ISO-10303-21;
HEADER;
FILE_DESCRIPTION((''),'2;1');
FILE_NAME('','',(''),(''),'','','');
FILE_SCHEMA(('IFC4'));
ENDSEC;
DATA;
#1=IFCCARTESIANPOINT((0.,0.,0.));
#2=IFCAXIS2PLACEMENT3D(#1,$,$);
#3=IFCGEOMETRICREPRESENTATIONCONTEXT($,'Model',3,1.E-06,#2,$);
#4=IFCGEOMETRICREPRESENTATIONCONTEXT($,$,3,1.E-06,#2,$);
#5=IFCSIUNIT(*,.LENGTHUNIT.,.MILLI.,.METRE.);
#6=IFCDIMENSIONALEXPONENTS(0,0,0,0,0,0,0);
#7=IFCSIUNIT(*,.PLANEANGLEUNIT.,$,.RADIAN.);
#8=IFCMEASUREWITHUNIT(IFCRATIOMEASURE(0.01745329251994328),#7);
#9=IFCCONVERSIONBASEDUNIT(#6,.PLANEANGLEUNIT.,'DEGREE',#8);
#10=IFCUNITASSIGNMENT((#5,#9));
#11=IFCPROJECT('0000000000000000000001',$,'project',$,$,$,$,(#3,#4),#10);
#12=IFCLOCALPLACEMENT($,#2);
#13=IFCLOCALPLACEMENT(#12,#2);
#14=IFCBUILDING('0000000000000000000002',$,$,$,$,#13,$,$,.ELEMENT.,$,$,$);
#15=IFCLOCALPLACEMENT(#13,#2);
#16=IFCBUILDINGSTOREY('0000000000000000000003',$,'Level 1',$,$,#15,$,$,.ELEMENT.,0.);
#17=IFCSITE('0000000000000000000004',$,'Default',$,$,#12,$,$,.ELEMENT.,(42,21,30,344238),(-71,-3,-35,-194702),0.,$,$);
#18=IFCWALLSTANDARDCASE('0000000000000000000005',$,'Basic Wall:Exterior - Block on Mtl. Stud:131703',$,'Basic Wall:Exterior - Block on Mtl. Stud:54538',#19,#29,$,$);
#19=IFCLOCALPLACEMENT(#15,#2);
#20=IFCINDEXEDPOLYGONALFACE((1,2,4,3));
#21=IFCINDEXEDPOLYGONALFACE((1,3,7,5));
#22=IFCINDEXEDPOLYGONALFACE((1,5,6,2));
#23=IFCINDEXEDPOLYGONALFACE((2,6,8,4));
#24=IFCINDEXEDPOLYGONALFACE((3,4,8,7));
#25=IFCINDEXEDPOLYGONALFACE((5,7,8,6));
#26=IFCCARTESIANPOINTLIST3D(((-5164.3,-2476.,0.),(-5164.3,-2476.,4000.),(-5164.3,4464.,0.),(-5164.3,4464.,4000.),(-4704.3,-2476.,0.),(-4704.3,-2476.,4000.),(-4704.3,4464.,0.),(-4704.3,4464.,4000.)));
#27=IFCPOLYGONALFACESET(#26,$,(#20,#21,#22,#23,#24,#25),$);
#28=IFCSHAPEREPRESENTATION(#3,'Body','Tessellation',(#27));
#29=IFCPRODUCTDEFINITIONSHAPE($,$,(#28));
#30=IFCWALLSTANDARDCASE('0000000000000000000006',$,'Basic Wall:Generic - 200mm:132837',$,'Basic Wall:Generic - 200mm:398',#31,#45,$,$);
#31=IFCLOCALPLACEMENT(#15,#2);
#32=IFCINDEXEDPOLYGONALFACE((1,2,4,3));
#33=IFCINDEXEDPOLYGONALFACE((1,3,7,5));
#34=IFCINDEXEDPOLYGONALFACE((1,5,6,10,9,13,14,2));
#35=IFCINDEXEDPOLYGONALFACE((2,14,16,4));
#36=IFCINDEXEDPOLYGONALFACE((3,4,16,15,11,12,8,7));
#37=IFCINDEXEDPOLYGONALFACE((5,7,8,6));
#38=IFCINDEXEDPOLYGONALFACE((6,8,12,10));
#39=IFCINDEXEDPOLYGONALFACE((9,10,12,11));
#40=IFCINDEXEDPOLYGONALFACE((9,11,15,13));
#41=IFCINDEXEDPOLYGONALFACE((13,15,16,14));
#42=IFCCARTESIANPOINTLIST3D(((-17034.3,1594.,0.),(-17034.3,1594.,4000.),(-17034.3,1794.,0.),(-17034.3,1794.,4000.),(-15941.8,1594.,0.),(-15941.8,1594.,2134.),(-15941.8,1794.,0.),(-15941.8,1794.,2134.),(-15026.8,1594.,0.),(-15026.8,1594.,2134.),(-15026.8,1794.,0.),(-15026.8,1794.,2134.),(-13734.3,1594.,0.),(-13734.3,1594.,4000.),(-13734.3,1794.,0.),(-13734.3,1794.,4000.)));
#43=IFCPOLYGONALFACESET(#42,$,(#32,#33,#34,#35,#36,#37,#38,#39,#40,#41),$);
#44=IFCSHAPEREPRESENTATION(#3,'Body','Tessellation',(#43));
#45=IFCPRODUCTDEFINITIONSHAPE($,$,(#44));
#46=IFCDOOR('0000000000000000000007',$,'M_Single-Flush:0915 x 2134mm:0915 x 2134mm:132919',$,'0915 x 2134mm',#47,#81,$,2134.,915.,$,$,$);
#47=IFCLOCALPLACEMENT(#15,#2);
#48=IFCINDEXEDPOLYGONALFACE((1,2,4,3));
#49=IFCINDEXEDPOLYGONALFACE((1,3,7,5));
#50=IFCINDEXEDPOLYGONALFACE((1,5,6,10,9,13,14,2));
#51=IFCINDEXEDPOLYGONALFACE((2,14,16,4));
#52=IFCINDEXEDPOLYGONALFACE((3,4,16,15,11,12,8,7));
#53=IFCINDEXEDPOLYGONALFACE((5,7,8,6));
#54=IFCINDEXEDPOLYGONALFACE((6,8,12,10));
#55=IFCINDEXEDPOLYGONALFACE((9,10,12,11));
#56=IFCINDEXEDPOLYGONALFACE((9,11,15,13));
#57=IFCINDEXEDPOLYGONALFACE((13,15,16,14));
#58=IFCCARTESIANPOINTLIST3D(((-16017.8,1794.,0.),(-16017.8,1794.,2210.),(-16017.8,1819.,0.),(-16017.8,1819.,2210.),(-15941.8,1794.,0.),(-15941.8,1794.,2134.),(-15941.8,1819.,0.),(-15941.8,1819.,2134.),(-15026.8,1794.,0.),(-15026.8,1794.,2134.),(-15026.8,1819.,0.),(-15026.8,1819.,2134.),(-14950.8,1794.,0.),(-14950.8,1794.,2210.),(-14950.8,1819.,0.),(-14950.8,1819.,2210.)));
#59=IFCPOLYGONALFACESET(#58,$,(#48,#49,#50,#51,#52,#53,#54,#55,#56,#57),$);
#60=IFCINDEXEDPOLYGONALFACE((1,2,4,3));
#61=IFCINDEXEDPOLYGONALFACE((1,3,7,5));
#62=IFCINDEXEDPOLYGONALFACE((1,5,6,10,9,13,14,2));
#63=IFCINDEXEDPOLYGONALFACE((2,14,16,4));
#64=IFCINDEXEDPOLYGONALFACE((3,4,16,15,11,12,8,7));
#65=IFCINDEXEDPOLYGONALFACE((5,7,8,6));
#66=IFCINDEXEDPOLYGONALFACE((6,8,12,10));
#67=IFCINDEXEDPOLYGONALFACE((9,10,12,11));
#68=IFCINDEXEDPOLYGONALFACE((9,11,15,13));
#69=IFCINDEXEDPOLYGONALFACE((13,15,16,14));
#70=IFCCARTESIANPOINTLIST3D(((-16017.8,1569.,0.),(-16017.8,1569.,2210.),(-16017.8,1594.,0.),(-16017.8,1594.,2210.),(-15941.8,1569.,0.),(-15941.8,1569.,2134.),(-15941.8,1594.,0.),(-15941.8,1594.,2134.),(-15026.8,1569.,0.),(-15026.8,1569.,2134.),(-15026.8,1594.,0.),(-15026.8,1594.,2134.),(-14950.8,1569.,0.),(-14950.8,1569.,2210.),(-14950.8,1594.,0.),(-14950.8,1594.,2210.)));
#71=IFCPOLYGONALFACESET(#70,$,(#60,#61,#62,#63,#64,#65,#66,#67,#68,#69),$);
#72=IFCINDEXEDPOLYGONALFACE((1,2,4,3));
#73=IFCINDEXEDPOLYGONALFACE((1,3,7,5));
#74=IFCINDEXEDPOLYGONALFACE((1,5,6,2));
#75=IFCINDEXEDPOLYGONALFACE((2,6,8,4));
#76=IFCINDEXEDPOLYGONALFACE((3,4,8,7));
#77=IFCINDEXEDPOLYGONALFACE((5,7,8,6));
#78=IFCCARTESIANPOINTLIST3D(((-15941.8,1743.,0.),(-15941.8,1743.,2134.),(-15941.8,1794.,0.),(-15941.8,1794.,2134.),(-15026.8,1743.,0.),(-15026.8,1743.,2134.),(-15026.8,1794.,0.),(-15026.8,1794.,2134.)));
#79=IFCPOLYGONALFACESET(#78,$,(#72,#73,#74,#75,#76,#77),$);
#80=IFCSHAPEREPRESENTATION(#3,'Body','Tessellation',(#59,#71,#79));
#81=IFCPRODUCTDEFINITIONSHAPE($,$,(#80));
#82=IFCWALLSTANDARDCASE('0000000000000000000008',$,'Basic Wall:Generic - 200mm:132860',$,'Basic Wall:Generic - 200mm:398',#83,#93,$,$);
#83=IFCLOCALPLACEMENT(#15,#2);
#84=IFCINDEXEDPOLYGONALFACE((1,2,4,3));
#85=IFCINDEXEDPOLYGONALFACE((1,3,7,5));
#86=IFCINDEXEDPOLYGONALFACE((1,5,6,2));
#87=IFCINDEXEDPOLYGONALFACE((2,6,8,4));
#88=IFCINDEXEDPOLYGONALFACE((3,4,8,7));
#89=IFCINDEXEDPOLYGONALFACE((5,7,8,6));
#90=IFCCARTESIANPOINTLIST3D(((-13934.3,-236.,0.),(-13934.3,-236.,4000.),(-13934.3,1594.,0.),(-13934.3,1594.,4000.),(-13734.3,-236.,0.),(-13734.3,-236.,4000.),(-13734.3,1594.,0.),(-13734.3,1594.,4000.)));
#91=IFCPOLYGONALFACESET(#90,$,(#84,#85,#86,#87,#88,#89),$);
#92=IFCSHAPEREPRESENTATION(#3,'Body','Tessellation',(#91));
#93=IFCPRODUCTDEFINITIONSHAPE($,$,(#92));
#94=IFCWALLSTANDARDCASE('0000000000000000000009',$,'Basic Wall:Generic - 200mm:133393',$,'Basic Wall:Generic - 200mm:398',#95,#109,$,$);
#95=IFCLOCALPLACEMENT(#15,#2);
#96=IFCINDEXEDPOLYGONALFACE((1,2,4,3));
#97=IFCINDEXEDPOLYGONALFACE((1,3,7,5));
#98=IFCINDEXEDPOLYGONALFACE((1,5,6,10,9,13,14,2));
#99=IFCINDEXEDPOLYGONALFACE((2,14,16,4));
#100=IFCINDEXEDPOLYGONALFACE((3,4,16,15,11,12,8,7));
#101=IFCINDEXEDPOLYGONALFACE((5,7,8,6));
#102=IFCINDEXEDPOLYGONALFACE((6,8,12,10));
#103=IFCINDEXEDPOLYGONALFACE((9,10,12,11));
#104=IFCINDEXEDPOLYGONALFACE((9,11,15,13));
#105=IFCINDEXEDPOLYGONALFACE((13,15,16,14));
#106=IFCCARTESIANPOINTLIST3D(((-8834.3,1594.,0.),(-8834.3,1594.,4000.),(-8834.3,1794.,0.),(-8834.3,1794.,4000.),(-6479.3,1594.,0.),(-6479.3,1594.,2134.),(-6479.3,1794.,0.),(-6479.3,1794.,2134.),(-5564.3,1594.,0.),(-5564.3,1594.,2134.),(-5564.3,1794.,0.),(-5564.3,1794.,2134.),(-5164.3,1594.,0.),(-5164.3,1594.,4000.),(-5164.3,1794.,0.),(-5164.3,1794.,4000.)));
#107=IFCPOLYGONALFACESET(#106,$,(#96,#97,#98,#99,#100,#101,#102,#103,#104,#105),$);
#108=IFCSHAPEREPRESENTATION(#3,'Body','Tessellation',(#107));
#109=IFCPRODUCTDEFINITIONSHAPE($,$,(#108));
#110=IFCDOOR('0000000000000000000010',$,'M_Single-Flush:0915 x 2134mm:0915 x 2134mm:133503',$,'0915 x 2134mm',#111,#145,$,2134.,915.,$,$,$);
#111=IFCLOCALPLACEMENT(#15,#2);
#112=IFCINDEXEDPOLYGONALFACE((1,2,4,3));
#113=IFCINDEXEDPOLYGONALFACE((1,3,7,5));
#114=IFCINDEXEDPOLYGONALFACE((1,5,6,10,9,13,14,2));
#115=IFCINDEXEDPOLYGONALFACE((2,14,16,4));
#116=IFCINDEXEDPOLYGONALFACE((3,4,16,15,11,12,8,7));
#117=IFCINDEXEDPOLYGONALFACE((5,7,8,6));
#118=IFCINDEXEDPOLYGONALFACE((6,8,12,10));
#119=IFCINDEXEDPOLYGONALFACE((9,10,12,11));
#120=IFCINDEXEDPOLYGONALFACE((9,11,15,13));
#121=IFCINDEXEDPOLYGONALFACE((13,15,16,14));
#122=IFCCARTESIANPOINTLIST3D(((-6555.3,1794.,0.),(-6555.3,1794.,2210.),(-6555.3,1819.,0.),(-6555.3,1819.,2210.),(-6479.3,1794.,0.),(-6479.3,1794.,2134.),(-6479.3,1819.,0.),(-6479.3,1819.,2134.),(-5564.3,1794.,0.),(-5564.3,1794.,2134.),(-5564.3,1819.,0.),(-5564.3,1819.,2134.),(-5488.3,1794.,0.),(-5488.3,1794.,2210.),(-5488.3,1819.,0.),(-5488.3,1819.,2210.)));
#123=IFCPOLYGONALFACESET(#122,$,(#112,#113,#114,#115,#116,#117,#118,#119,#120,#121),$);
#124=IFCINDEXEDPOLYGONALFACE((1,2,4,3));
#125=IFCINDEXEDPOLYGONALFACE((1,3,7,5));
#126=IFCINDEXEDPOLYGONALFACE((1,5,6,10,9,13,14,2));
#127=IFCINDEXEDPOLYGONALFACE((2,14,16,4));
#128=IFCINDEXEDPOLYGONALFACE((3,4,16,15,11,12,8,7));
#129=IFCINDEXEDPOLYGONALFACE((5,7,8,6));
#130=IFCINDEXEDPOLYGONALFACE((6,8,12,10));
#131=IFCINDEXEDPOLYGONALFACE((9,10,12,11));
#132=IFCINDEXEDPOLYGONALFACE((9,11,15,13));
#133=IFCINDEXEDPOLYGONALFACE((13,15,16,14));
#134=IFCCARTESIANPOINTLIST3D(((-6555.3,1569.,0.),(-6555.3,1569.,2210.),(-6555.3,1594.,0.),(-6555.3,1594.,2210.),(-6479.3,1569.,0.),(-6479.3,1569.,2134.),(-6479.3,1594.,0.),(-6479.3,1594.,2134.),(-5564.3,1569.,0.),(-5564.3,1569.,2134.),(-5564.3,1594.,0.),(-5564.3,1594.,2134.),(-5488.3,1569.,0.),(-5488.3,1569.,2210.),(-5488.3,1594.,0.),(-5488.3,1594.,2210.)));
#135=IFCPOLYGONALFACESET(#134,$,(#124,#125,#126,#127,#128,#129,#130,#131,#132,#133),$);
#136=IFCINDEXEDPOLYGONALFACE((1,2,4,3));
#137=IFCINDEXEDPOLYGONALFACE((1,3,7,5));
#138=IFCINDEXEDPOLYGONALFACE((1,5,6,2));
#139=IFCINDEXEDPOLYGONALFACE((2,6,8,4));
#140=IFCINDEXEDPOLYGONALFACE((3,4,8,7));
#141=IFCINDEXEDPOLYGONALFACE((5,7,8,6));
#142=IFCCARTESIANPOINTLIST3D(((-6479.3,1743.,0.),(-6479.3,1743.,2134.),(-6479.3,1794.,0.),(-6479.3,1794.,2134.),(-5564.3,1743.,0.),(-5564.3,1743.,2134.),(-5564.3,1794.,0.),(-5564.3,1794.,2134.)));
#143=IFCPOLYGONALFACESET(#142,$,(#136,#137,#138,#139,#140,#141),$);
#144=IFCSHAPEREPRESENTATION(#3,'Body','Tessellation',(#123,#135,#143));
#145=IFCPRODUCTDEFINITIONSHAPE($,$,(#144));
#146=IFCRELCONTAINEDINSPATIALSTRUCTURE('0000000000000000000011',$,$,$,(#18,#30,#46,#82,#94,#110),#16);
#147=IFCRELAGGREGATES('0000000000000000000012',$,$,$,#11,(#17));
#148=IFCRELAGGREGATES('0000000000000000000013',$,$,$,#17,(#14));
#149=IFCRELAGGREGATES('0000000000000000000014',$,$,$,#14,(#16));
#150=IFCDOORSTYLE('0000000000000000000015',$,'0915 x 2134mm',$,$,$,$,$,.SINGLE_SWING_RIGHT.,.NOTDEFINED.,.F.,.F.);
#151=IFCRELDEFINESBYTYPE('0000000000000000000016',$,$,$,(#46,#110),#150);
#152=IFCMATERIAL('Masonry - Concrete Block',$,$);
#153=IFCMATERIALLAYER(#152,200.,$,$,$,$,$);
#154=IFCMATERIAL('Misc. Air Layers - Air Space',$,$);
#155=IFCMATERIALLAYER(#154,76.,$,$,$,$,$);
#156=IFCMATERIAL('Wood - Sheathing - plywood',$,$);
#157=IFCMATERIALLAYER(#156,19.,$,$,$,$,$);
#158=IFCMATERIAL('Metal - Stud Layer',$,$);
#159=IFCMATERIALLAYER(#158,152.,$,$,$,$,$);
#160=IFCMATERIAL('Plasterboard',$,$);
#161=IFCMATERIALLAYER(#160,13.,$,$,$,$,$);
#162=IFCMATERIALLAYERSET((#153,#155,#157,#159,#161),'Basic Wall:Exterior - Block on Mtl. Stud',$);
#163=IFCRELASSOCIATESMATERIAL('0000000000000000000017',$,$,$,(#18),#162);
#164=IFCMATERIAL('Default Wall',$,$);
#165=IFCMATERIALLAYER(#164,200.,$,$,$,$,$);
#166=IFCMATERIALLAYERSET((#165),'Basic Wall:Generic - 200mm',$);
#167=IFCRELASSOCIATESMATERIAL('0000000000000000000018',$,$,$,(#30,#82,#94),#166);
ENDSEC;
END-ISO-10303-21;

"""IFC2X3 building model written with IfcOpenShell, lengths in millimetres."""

from ifc_helpers import new_model, entity, si_unit, converted_unit, frame, frame_2d, origin, origin_2d_with_axis, place, context, project, spatial, polyline, rectangle, outline, extrude, source, transform, mapped, material, layer, layer_set, layer_usage, type_object, type_shapes, element, fill, save


model = new_model("IFC2X3")

# Units and contexts
model_context = context("Model", 3, precision=1e-06, world=origin())
context_of_model = context(None, 3, precision=1e-06, world=origin())
ifc_project = project(units=[si_unit("LENGTHUNIT", "METRE", prefix="MILLI"), converted_unit("PLANEANGLEUNIT", "DEGREE", entity("IfcRatioMeasure", 0.01745329251994328), si_unit("PLANEANGLEUNIT", "RADIAN"), dimensions=[0, 0, 0, 0, 0, 0, 0])], contexts=[model_context, context_of_model])

# Site, building, storey
site_placement = place(None, origin())
site = spatial("IfcSite", under=ifc_project, at=site_placement, Name="Default", CompositionType="ELEMENT", RefLatitude=(42, 21, 30, 344238), RefLongitude=(-71, -3, -35, -194702), RefElevation=0.0)
building_placement = place(site_placement, origin())
building = spatial("IfcBuilding", under=site, at=building_placement, CompositionType="ELEMENT")
storey_placement = place(building_placement, origin())
storey = spatial("IfcBuildingStorey", under=building, at=storey_placement, Name="Level 1", CompositionType="ELEMENT", Elevation=0.0)

# Shared definitions
ifc_material_1 = material(Name="Masonry - Concrete Block")
ifc_layer_1 = layer(ifc_material_1, 200.0)
ifc_material_2 = material(Name="Misc. Air Layers - Air Space")
ifc_layer_2 = layer(ifc_material_2, 76.0)
ifc_material_3 = material(Name="Wood - Sheathing - plywood")
ifc_layer_3 = layer(ifc_material_3, 19.0)
ifc_material_4 = material(Name="Metal - Stud Layer")
ifc_layer_4 = layer(ifc_material_4, 152.0)
ifc_material_5 = material(Name="Plasterboard")
ifc_layer_5 = layer(ifc_material_5, 13.0)
ifc_layer_set_1 = layer_set([ifc_layer_1, ifc_layer_2, ifc_layer_3, ifc_layer_4, ifc_layer_5], Name="Basic Wall:Exterior - Block on Mtl. Stud")

# Shared definitions
ifc_material_6 = material(Name="Default Wall")
ifc_layer_6 = layer(ifc_material_6, 200.0)
ifc_layer_set_2 = layer_set([ifc_layer_6], Name="Basic Wall:Generic - 200mm")
door_style = type_object("IfcDoorStyle", Name="0915 x 2134mm", ConstructionType="NOTDEFINED", OperationType="SINGLE_SWING_RIGHT", ParameterTakesPrecedence=False, Sizeable=False)
shared_shape_1 = source(origin(), model_context, "Body", "SweptSolid", [
    extrude(outline(polyline([(-533.5, -1124.0), (533.5, -1124.0), (533.5, 1086.0), (457.5, 1086.0), (457.5, -1048.0), (-457.5, -1048.0), (-457.5, 1086.0), (-533.5, 1086.0), (-533.5, -1124.0)])), frame((457.5, 200.0, 1086.0), z_axis=(0.0, 1.0, 0.0), x_axis=(1.0, 0.0, 0.0)), (0.0, 0.0, 1.0), 25.0),
    extrude(outline(polyline([(-1124.0, -533.5), (1086.0, -533.5), (1086.0, -457.5), (-1048.0, -457.5), (-1048.0, 457.5), (1086.0, 457.5), (1086.0, 533.5), (-1124.0, 533.5), (-1124.0, -533.5)])), frame((457.5, -25.0, 1086.0), z_axis=(0.0, 1.0, 0.0), x_axis=(0.0, 0.0, -1.0)), (0.0, 0.0, 1.0), 25.0),
    extrude(rectangle(XDim=51.0, YDim=915.0, at=origin_2d_with_axis()), frame((457.5, 174.5, 0.0), z_axis=(0.0, 0.0, 1.0), x_axis=(0.0, 1.0, 0.0)), (0.0, 0.0, 1.0), 2134.0),
])
type_shapes(door_style, [shared_shape_1])

# Wall
ifc_layer_usage_1 = layer_usage(ifc_layer_set_1, "AXIS2", "NEGATIVE", 230.0)
wall_1_placement = place(storey_placement, frame((-4934.3, 4464.0, 0.0), z_axis=(0.0, 0.0, 1.0), x_axis=(0.0, -1.0, 0.0)))
element("IfcWallStandardCase", 1, at=wall_1_placement, inside=storey, material=ifc_layer_usage_1, Name="Basic Wall:Exterior - Block on Mtl. Stud:131703", ObjectType="Basic Wall:Exterior - Block on Mtl. Stud:54538", context=model_context, shape_type="SweptSolid", body=[
    extrude(rectangle(XDim=6940.0, YDim=460.0, at=frame_2d((3470.0, 0.0), x_axis=(-1.0, 0.0))), origin(), (0.0, 0.0, 1.0), 4000.0),
])

# Wall, opening, door
ifc_layer_usage_2 = layer_usage(ifc_layer_set_2, "AXIS2", "NEGATIVE", 100.0)
wall_2_placement = place(storey_placement, frame((-17034.3, 1694.0, 0.0)))
wall_2 = element("IfcWallStandardCase", 2, at=wall_2_placement, inside=storey, material=ifc_layer_usage_2, Name="Basic Wall:Generic - 200mm:132837", ObjectType="Basic Wall:Generic - 200mm:398", context=model_context, shape_type="SweptSolid", body=[
    extrude(rectangle(XDim=3300.0, YDim=200.0, at=frame_2d((1650.0, 0.0), x_axis=(-1.0, 0.0))), origin(), (0.0, 0.0, 1.0), 4000.0),
])
opening_1_placement = place(wall_2_placement, frame((1092.5, -100.0, 0.0)))
opening_1 = element("IfcOpeningElement", 3, at=opening_1_placement, cuts=wall_2, ObjectType="Opening", context=model_context, shape_type="SweptSolid", body=[
    extrude(rectangle(XDim=915.0, YDim=2134.0, at=frame_2d((1067.0, 457.5), x_axis=(0.0, 1.0))), frame((0.0, 0.0, 0.0), z_axis=(0.0, 1.0, 0.0), x_axis=(0.0, 0.0, 1.0)), (0.0, 0.0, 1.0), 200.0),
])
door_1_placement = place(opening_1_placement, origin())
door_1 = element("IfcDoor", 4, at=door_1_placement, inside=storey, type_object=door_style, Name="M_Single-Flush:0915 x 2134mm:0915 x 2134mm:132919", ObjectType="0915 x 2134mm", OverallHeight=2134.0, OverallWidth=915.0, context=model_context, shape_type="MappedRepresentation", body=[
    mapped(shared_shape_1, transform((0.0, 0.0, 0.0), scale=1.0)),
])
fill(opening_1, door_1)

# Wall
ifc_layer_usage_3 = layer_usage(ifc_layer_set_2, "AXIS2", "NEGATIVE", 100.0)
wall_3_placement = place(storey_placement, frame((-13834.3, 1594.0, 0.0), z_axis=(0.0, 0.0, 1.0), x_axis=(0.0, -1.0, 0.0)))
element("IfcWallStandardCase", 5, at=wall_3_placement, inside=storey, material=ifc_layer_usage_3, Name="Basic Wall:Generic - 200mm:132860", ObjectType="Basic Wall:Generic - 200mm:398", context=model_context, shape_type="SweptSolid", body=[
    extrude(rectangle(XDim=1830.0, YDim=200.0, at=frame_2d((915.0, 0.0), x_axis=(-1.0, 0.0))), origin(), (0.0, 0.0, 1.0), 4000.0),
])

# Wall, opening, door
ifc_layer_usage_4 = layer_usage(ifc_layer_set_2, "AXIS2", "NEGATIVE", 100.0)
wall_4_placement = place(storey_placement, frame((-5164.3, 1694.0, 0.0), z_axis=(0.0, 0.0, 1.0), x_axis=(-1.0, 0.0, 0.0)))
wall_4 = element("IfcWallStandardCase", 6, at=wall_4_placement, inside=storey, material=ifc_layer_usage_4, Name="Basic Wall:Generic - 200mm:133393", ObjectType="Basic Wall:Generic - 200mm:398", context=model_context, shape_type="SweptSolid", body=[
    extrude(rectangle(XDim=3670.0, YDim=200.0, at=frame_2d((1835.0, 0.0), x_axis=(-1.0, 0.0))), origin(), (0.0, 0.0, 1.0), 4000.0),
])
opening_2_placement = place(wall_4_placement, frame((1315.0, 100.0, 0.0)))
opening_2 = element("IfcOpeningElement", 7, at=opening_2_placement, cuts=wall_4, ObjectType="Opening", context=model_context, shape_type="SweptSolid", body=[
    extrude(rectangle(XDim=915.0, YDim=2134.0, at=frame_2d((1067.0, 457.5), x_axis=(0.0, 1.0))), frame((0.0, 0.0, 0.0), z_axis=(0.0, -1.0, 0.0), x_axis=(0.0, 0.0, 1.0)), (0.0, 0.0, 1.0), 200.0),
])
door_2_placement = place(opening_2_placement, frame((0.0, 0.0, 0.0), z_axis=(0.0, 0.0, 1.0), x_axis=(-1.0, 0.0, 0.0)))
door_2 = element("IfcDoor", 8, at=door_2_placement, inside=storey, type_object=door_style, Name="M_Single-Flush:0915 x 2134mm:0915 x 2134mm:133503", ObjectType="0915 x 2134mm", OverallHeight=2134.0, OverallWidth=915.0, context=model_context, shape_type="MappedRepresentation", body=[
    mapped(shared_shape_1, transform((0.0, 0.0, 0.0), scale=1.0)),
])
fill(opening_2, door_2)

save(model, "model.ifc")
